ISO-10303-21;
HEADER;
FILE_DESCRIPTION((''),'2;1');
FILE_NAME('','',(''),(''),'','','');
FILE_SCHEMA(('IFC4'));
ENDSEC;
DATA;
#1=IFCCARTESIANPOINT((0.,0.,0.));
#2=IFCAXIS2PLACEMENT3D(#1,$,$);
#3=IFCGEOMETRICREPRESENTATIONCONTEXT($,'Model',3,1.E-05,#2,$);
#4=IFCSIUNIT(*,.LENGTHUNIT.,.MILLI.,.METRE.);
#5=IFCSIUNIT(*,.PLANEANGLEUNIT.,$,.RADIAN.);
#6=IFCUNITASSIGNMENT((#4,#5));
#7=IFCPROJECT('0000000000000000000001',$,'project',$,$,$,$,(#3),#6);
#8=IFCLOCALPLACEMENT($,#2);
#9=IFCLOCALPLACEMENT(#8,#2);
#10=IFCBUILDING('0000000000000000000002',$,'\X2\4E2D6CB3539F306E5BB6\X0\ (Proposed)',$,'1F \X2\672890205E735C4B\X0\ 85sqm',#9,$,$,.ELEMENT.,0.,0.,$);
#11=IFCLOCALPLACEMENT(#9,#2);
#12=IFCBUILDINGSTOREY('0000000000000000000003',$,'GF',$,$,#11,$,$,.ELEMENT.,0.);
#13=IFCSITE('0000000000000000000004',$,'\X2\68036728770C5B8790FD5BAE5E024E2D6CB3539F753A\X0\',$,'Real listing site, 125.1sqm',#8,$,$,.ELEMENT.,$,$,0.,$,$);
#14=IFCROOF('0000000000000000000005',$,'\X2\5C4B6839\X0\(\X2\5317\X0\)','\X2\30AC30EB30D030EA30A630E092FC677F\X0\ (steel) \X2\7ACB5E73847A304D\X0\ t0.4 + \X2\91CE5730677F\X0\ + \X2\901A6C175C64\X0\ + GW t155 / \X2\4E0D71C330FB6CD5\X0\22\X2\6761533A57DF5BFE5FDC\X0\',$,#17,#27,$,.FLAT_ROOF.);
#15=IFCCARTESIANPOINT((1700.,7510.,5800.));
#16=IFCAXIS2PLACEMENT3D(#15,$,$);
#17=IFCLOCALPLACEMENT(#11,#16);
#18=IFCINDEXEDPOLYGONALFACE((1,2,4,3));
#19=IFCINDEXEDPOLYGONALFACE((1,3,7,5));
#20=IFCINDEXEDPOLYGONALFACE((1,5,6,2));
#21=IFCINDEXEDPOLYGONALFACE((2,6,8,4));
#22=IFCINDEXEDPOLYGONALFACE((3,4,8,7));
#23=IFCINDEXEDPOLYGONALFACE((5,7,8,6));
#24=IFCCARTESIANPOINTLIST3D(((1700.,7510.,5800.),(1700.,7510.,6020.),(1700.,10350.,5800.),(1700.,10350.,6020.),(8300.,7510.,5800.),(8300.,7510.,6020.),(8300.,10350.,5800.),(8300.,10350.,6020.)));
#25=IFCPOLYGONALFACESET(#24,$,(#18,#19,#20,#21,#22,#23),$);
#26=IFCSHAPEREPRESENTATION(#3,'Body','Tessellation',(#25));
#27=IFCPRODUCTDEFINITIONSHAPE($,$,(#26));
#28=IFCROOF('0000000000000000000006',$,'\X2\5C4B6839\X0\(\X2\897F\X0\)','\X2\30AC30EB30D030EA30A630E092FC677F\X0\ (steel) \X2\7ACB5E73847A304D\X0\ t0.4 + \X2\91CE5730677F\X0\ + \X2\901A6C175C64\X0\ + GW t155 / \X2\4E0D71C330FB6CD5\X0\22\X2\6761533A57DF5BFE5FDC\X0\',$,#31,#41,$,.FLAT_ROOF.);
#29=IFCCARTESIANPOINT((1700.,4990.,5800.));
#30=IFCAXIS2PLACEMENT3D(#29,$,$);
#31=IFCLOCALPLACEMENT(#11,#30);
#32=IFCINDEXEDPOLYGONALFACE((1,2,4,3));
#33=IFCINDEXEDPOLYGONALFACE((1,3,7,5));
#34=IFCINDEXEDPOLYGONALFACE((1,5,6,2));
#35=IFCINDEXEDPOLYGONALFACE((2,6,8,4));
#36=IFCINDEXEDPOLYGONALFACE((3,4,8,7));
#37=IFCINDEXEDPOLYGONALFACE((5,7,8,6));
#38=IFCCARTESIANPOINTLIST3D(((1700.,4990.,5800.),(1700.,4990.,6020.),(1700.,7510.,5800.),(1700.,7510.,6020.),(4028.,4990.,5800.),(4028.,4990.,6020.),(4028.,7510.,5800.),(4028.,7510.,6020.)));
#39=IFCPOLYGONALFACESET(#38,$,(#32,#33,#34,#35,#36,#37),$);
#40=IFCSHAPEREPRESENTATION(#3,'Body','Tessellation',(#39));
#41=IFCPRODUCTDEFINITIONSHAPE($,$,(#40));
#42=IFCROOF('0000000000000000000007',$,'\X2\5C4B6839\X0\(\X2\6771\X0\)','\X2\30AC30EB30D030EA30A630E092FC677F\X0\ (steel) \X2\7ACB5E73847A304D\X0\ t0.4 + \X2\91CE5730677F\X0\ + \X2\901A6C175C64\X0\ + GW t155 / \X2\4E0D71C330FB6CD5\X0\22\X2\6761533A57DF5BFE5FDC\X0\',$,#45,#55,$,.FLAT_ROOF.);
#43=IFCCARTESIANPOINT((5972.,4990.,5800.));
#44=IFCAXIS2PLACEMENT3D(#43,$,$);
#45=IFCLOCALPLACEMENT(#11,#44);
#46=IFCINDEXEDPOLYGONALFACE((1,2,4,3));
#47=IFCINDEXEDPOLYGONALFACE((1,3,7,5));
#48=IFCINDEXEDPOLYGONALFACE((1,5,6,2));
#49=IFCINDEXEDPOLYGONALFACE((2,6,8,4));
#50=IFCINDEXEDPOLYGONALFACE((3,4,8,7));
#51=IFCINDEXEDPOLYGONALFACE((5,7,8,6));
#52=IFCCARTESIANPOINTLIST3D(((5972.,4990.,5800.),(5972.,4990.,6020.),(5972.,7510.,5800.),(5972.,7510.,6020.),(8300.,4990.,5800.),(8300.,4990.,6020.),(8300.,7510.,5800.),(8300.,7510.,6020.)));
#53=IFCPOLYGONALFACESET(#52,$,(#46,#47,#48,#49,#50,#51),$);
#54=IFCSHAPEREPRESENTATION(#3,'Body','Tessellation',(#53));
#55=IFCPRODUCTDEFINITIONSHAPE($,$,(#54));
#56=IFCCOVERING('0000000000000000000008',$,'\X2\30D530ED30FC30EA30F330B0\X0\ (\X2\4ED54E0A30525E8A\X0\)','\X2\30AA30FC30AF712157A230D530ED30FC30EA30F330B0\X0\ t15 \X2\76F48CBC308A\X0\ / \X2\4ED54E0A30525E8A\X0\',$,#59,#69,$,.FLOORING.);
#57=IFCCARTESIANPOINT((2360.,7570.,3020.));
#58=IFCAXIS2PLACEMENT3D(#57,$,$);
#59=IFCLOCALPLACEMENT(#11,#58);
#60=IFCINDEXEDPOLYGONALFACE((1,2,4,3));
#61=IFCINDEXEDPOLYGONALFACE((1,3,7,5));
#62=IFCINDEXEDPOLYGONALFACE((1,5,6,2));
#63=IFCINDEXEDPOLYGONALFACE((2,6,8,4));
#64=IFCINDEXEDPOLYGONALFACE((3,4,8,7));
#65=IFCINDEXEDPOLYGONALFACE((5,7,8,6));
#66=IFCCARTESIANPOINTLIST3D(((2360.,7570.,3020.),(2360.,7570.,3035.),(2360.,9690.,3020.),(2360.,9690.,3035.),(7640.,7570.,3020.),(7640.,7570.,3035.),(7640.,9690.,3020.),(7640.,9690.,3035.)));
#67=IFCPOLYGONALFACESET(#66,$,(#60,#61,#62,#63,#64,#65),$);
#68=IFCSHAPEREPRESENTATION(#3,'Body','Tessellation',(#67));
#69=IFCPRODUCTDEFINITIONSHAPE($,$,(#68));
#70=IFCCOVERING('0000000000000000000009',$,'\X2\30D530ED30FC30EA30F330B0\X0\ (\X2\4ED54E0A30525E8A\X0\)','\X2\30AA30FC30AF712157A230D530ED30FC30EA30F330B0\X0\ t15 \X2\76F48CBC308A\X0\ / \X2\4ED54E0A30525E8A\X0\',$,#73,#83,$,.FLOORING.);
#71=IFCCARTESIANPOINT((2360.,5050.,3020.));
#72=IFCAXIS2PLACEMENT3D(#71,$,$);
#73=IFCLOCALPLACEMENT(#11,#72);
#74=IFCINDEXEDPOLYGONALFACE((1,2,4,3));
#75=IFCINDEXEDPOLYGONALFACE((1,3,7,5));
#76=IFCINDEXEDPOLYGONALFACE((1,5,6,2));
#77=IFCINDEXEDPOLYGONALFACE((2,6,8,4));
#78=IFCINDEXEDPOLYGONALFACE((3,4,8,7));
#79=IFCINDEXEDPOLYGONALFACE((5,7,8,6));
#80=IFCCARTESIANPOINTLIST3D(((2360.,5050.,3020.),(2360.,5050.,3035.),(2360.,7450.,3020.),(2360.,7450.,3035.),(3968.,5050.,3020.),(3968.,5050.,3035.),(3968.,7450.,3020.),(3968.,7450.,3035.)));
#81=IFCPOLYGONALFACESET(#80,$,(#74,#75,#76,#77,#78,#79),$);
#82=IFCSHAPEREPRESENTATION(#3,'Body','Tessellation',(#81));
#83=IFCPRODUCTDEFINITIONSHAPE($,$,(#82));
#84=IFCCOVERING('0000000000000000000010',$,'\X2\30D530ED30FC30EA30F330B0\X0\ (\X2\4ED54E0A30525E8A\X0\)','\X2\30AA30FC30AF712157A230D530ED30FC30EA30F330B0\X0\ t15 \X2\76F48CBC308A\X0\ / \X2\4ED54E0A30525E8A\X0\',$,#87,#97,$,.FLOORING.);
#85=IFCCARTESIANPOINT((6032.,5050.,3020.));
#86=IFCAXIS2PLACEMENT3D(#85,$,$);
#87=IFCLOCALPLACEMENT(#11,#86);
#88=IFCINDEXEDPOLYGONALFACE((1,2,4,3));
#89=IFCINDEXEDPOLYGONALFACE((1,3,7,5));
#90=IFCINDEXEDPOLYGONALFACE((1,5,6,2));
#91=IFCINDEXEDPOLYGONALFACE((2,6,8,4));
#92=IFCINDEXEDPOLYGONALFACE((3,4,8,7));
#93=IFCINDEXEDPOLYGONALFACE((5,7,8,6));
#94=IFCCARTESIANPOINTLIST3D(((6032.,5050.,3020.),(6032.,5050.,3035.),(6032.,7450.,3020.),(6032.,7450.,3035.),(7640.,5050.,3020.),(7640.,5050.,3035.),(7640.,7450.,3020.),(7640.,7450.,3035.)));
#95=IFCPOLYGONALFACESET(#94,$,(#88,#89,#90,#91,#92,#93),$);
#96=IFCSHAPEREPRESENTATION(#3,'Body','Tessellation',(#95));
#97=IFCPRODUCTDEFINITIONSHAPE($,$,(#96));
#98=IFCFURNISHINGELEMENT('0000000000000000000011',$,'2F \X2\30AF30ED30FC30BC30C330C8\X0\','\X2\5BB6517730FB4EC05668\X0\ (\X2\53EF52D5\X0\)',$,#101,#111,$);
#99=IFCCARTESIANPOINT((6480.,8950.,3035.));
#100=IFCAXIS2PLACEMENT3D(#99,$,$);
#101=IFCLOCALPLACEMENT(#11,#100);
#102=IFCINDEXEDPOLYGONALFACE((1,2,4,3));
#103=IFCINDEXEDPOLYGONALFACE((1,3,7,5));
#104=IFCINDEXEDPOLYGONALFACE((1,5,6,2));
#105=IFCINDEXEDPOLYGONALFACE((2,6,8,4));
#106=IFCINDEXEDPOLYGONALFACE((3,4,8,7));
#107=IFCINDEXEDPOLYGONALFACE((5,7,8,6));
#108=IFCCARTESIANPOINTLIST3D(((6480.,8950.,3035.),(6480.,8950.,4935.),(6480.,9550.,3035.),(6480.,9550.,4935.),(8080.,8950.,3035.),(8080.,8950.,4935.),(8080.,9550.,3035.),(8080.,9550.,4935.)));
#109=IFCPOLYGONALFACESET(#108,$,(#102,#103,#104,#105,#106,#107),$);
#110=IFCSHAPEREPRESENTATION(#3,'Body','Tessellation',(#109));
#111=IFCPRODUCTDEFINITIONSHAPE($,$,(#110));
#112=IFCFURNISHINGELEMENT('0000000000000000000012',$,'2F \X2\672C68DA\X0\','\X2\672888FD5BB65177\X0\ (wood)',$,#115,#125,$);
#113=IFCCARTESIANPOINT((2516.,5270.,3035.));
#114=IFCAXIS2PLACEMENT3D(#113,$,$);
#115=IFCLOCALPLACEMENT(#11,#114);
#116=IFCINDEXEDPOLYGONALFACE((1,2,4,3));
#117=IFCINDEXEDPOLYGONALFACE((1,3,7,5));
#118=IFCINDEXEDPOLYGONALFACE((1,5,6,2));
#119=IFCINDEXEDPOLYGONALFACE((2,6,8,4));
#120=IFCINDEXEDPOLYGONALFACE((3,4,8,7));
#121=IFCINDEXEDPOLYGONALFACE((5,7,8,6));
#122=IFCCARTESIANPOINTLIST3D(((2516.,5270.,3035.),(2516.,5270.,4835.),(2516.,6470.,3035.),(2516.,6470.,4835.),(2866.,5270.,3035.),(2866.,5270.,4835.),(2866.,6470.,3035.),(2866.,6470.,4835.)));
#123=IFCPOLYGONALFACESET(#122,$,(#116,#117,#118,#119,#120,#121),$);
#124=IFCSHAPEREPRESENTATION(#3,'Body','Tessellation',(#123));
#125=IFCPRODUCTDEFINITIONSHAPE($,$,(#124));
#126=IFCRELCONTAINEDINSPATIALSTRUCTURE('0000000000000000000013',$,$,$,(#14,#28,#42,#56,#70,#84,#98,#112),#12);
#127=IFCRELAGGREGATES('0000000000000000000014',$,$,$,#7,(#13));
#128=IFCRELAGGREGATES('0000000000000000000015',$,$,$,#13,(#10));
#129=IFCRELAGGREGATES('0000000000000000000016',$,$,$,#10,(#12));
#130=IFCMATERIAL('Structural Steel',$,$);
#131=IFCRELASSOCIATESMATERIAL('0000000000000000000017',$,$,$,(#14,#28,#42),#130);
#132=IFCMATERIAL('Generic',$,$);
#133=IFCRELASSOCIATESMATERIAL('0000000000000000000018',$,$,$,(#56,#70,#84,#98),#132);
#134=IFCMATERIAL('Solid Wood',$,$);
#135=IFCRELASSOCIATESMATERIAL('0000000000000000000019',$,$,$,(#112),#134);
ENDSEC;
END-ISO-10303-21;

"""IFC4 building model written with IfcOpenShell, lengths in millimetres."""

from ifc_helpers import new_model, si_unit, frame, frame_2d, origin, place, context, project, spatial, rectangle, extrude, material, element, save


model = new_model("IFC4")

# Units and contexts
model_context = context("Model", 3, precision=1e-05, world=origin())
ifc_project = project(units=[si_unit("LENGTHUNIT", "METRE", prefix="MILLI"), si_unit("PLANEANGLEUNIT", "RADIAN")], contexts=[model_context])

# Site, building, storey
site_placement = place(None, origin())
site = spatial("IfcSite", under=ifc_project, at=site_placement, Name="栃木県宇都宮市中河原町", ObjectType="Real listing site, 125.1sqm", CompositionType="ELEMENT", RefElevation=0.0)
building_placement = place(site_placement, origin())
building = spatial("IfcBuilding", under=site, at=building_placement, Name="中河原の家 (Proposed)", ObjectType="1F 木造平屋 85sqm", CompositionType="ELEMENT", ElevationOfRefHeight=0.0, ElevationOfTerrain=0.0)
storey_placement = place(building_placement, origin())
storey = spatial("IfcBuildingStorey", under=building, at=storey_placement, Name="GF", CompositionType="ELEMENT", Elevation=0.0)

# Shared definitions
ifc_material_1 = material(Name="Solid Wood")

# Shared definitions
ifc_material_2 = material(Name="Generic")

# Roofs
ifc_material_3 = material(Name="Structural Steel")
for number, where, name in (
    (1, (1700.0, 7510.0, 5800.0), "屋根(北)"),
):
    element("IfcRoof", number, at=place(storey_placement, frame(where)), inside=storey, material=ifc_material_3, Name=name, Description="ガルバリウム鋼板 (steel) 立平葺き t0.4 + 野地板 + 通気層 + GW t155 / 不燃・法22条区域対応", PredefinedType="FLAT_ROOF", context=model_context, shape_type="SweptSolid", body=[
        extrude(rectangle(XDim=6600.0, YDim=2840.0, at=frame_2d((3300.0, 1420.0))), frame((1700.0, 7510.0, 5800.0)), (0.0, 0.0, 1.0), 220.0),
    ])
roof_1_placement = place(storey_placement, frame((1700.0, 4990.0, 5800.0)))
element("IfcRoof", 2, at=roof_1_placement, inside=storey, material=ifc_material_3, Name="屋根(西)", Description="ガルバリウム鋼板 (steel) 立平葺き t0.4 + 野地板 + 通気層 + GW t155 / 不燃・法22条区域対応", PredefinedType="FLAT_ROOF", context=model_context, shape_type="SweptSolid", body=[
    extrude(rectangle(XDim=2328.0, YDim=2520.0, at=frame_2d((1164.0, 1260.0))), frame((1700.0, 4990.0, 5800.0)), (0.0, 0.0, 1.0), 220.0),
])
roof_2_placement = place(storey_placement, frame((5972.0, 4990.0, 5800.0)))
element("IfcRoof", 3, at=roof_2_placement, inside=storey, material=ifc_material_3, Name="屋根(東)", Description="ガルバリウム鋼板 (steel) 立平葺き t0.4 + 野地板 + 通気層 + GW t155 / 不燃・法22条区域対応", PredefinedType="FLAT_ROOF", context=model_context, shape_type="SweptSolid", body=[
    extrude(rectangle(XDim=2328.0, YDim=2520.0, at=frame_2d((1164.0, 1260.0))), frame((5972.0, 4990.0, 5800.0)), (0.0, 0.0, 1.0), 220.0),
])

# Coverings
covering_1_placement = place(storey_placement, frame((2360.0, 7570.0, 3020.0)))
element("IfcCovering", 4, at=covering_1_placement, inside=storey, material=ifc_material_2, Name="フローリング (仕上げ床)", Description="オーク無垢フローリング t15 直貼り / 仕上げ床", PredefinedType="FLOORING", context=model_context, shape_type="SweptSolid", body=[
    extrude(rectangle(XDim=5280.0, YDim=2120.0, at=frame_2d((2640.0, 1060.0))), frame((2360.0, 7570.0, 3020.0)), (0.0, 0.0, 1.0), 15.0),
])
covering_2_placement = place(storey_placement, frame((2360.0, 5050.0, 3020.0)))
element("IfcCovering", 5, at=covering_2_placement, inside=storey, material=ifc_material_2, Name="フローリング (仕上げ床)", Description="オーク無垢フローリング t15 直貼り / 仕上げ床", PredefinedType="FLOORING", context=model_context, shape_type="SweptSolid", body=[
    extrude(rectangle(XDim=1608.0, YDim=2400.0, at=frame_2d((804.0, 1200.0))), frame((2360.0, 5050.0, 3020.0)), (0.0, 0.0, 1.0), 15.0),
])
covering_3_placement = place(storey_placement, frame((6032.0, 5050.0, 3020.0)))
element("IfcCovering", 6, at=covering_3_placement, inside=storey, material=ifc_material_2, Name="フローリング (仕上げ床)", Description="オーク無垢フローリング t15 直貼り / 仕上げ床", PredefinedType="FLOORING", context=model_context, shape_type="SweptSolid", body=[
    extrude(rectangle(XDim=1608.0, YDim=2400.0, at=frame_2d((804.0, 1200.0))), frame((6032.0, 5050.0, 3020.0)), (0.0, 0.0, 1.0), 15.0),
])

# Furnishing elements
furnishing_1_placement = place(storey_placement, frame((6480.0, 8950.0, 3035.0)))
element("IfcFurnishingElement", 7, at=furnishing_1_placement, inside=storey, material=ifc_material_2, Name="2F クローゼット", Description="家具・什器 (可動)", context=model_context, shape_type="SweptSolid", body=[
    extrude(rectangle(XDim=1600.0, YDim=600.0, at=frame_2d((800.0, 300.0))), frame((6480.0, 8950.0, 3035.0)), (0.0, 0.0, 1.0), 1900.0),
])
furnishing_2_placement = place(storey_placement, frame((2516.0, 5270.0, 3035.0)))
element("IfcFurnishingElement", 8, at=furnishing_2_placement, inside=storey, material=ifc_material_1, Name="2F 本棚", Description="木製家具 (wood)", context=model_context, shape_type="SweptSolid", body=[
    extrude(rectangle(XDim=350.0, YDim=1200.0, at=frame_2d((175.0, 600.0))), frame((2516.0, 5270.0, 3035.0)), (0.0, 0.0, 1.0), 1800.0),
])

save(model, "model.ifc")
